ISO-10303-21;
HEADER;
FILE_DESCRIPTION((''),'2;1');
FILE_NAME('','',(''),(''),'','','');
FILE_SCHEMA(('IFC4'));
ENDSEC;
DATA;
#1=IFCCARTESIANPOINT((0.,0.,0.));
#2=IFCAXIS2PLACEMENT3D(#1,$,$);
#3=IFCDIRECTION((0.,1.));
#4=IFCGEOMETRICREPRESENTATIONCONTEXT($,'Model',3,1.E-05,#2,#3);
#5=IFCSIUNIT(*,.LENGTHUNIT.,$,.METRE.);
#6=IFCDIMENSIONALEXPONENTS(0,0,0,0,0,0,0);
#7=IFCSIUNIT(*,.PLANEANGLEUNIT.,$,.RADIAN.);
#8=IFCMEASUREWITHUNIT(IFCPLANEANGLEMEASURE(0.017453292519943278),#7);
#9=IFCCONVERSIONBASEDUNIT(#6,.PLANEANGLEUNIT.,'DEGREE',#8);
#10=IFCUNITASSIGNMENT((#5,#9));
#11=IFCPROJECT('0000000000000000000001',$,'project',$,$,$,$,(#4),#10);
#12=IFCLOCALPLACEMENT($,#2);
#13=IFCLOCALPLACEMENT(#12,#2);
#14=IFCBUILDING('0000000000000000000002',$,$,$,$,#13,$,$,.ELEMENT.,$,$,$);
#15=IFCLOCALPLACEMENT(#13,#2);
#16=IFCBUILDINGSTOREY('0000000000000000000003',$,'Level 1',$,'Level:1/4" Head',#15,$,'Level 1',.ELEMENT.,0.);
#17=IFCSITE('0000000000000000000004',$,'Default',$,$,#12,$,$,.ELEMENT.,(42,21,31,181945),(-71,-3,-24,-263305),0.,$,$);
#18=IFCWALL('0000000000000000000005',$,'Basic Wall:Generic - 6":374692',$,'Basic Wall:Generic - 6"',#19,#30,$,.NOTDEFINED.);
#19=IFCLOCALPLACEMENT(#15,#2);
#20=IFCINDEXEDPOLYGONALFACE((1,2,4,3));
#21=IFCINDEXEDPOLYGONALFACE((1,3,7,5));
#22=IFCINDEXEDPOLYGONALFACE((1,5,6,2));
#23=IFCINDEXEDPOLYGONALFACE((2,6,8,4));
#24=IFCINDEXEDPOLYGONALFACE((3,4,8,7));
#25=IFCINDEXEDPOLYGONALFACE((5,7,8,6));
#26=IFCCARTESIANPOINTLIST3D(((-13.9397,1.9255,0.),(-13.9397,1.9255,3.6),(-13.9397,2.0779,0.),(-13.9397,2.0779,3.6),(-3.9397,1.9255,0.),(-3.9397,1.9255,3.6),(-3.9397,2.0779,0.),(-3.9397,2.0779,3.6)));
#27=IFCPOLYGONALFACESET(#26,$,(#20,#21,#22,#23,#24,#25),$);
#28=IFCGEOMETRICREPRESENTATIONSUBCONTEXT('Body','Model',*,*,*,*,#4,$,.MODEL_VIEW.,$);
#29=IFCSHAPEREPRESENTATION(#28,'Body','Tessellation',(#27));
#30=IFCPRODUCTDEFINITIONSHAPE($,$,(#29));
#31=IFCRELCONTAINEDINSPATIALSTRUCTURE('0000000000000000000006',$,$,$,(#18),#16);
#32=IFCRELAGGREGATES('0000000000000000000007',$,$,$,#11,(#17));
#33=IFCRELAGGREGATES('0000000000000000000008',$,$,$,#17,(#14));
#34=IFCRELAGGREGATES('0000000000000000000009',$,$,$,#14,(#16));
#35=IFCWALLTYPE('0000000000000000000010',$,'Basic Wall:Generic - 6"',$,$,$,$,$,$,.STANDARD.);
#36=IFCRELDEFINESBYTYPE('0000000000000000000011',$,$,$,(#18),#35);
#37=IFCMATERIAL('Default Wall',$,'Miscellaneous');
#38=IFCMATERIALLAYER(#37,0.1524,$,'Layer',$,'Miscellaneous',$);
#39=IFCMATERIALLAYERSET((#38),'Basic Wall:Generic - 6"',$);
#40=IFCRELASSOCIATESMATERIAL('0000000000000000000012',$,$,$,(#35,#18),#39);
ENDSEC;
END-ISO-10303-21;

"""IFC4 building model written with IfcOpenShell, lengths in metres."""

from ifc_helpers import new_model, entity, si_unit, converted_unit, direction, frame, frame_2d, origin, place, context, subcontext, project, spatial, rectangle, extrude, material, layer, layer_set, layer_usage, type_object, element, save


model = new_model("IFC4")

# Units and contexts
model_context = context("Model", 3, precision=1e-05, world=origin(), true_north=direction((0.0, 1.0)))
body_context = subcontext(model_context, "Body", "Model", "MODEL_VIEW")
ifc_project = project(units=[si_unit("LENGTHUNIT", "METRE"), converted_unit("PLANEANGLEUNIT", "DEGREE", entity("IfcPlaneAngleMeasure", 0.017453292519943278), si_unit("PLANEANGLEUNIT", "RADIAN"), dimensions=[0, 0, 0, 0, 0, 0, 0])], contexts=[model_context])

# Site, building, storey
site_placement = place(None, origin())
site = spatial("IfcSite", under=ifc_project, at=site_placement, Name="Default", CompositionType="ELEMENT", RefLatitude=(42, 21, 31, 181945), RefLongitude=(-71, -3, -24, -263305), RefElevation=0.0)
building_placement = place(site_placement, origin())
building = spatial("IfcBuilding", under=site, at=building_placement, CompositionType="ELEMENT")
storey_placement = place(building_placement, origin())
storey = spatial("IfcBuildingStorey", under=building, at=storey_placement, Name="Level 1", ObjectType="Level:1/4\" Head", LongName="Level 1", CompositionType="ELEMENT", Elevation=0.0)

# Wall
ifc_material_1 = material(Name="Default Wall", Category="Miscellaneous")
ifc_layer_1 = layer(ifc_material_1, 0.1524, Name="Layer", Category="Miscellaneous")
ifc_layer_set_1 = layer_set([ifc_layer_1], Name="Basic Wall:Generic - 6\"")
ifc_layer_usage_1 = layer_usage(ifc_layer_set_1, "AXIS2", "NEGATIVE", 0.0762)
wall_type_1 = type_object("IfcWallType", Name="Basic Wall:Generic - 6\"", PredefinedType="STANDARD", material=ifc_layer_set_1)
wall_1_placement = place(storey_placement, frame((-13.9397, 2.0017, 0.0)))
element("IfcWall", 1, at=wall_1_placement, inside=storey, type_object=wall_type_1, material=ifc_layer_usage_1, Name="Basic Wall:Generic - 6\":374692", ObjectType="Basic Wall:Generic - 6\"", PredefinedType="NOTDEFINED", context=body_context, shape_type="SweptSolid", body=[
    extrude(rectangle(XDim=10.0, YDim=0.1524, at=frame_2d((5.0, 0.0), x_axis=(-1.0, 0.0))), origin(), (0.0, 0.0, 1.0), 3.6),
])

save(model, "model.ifc")
